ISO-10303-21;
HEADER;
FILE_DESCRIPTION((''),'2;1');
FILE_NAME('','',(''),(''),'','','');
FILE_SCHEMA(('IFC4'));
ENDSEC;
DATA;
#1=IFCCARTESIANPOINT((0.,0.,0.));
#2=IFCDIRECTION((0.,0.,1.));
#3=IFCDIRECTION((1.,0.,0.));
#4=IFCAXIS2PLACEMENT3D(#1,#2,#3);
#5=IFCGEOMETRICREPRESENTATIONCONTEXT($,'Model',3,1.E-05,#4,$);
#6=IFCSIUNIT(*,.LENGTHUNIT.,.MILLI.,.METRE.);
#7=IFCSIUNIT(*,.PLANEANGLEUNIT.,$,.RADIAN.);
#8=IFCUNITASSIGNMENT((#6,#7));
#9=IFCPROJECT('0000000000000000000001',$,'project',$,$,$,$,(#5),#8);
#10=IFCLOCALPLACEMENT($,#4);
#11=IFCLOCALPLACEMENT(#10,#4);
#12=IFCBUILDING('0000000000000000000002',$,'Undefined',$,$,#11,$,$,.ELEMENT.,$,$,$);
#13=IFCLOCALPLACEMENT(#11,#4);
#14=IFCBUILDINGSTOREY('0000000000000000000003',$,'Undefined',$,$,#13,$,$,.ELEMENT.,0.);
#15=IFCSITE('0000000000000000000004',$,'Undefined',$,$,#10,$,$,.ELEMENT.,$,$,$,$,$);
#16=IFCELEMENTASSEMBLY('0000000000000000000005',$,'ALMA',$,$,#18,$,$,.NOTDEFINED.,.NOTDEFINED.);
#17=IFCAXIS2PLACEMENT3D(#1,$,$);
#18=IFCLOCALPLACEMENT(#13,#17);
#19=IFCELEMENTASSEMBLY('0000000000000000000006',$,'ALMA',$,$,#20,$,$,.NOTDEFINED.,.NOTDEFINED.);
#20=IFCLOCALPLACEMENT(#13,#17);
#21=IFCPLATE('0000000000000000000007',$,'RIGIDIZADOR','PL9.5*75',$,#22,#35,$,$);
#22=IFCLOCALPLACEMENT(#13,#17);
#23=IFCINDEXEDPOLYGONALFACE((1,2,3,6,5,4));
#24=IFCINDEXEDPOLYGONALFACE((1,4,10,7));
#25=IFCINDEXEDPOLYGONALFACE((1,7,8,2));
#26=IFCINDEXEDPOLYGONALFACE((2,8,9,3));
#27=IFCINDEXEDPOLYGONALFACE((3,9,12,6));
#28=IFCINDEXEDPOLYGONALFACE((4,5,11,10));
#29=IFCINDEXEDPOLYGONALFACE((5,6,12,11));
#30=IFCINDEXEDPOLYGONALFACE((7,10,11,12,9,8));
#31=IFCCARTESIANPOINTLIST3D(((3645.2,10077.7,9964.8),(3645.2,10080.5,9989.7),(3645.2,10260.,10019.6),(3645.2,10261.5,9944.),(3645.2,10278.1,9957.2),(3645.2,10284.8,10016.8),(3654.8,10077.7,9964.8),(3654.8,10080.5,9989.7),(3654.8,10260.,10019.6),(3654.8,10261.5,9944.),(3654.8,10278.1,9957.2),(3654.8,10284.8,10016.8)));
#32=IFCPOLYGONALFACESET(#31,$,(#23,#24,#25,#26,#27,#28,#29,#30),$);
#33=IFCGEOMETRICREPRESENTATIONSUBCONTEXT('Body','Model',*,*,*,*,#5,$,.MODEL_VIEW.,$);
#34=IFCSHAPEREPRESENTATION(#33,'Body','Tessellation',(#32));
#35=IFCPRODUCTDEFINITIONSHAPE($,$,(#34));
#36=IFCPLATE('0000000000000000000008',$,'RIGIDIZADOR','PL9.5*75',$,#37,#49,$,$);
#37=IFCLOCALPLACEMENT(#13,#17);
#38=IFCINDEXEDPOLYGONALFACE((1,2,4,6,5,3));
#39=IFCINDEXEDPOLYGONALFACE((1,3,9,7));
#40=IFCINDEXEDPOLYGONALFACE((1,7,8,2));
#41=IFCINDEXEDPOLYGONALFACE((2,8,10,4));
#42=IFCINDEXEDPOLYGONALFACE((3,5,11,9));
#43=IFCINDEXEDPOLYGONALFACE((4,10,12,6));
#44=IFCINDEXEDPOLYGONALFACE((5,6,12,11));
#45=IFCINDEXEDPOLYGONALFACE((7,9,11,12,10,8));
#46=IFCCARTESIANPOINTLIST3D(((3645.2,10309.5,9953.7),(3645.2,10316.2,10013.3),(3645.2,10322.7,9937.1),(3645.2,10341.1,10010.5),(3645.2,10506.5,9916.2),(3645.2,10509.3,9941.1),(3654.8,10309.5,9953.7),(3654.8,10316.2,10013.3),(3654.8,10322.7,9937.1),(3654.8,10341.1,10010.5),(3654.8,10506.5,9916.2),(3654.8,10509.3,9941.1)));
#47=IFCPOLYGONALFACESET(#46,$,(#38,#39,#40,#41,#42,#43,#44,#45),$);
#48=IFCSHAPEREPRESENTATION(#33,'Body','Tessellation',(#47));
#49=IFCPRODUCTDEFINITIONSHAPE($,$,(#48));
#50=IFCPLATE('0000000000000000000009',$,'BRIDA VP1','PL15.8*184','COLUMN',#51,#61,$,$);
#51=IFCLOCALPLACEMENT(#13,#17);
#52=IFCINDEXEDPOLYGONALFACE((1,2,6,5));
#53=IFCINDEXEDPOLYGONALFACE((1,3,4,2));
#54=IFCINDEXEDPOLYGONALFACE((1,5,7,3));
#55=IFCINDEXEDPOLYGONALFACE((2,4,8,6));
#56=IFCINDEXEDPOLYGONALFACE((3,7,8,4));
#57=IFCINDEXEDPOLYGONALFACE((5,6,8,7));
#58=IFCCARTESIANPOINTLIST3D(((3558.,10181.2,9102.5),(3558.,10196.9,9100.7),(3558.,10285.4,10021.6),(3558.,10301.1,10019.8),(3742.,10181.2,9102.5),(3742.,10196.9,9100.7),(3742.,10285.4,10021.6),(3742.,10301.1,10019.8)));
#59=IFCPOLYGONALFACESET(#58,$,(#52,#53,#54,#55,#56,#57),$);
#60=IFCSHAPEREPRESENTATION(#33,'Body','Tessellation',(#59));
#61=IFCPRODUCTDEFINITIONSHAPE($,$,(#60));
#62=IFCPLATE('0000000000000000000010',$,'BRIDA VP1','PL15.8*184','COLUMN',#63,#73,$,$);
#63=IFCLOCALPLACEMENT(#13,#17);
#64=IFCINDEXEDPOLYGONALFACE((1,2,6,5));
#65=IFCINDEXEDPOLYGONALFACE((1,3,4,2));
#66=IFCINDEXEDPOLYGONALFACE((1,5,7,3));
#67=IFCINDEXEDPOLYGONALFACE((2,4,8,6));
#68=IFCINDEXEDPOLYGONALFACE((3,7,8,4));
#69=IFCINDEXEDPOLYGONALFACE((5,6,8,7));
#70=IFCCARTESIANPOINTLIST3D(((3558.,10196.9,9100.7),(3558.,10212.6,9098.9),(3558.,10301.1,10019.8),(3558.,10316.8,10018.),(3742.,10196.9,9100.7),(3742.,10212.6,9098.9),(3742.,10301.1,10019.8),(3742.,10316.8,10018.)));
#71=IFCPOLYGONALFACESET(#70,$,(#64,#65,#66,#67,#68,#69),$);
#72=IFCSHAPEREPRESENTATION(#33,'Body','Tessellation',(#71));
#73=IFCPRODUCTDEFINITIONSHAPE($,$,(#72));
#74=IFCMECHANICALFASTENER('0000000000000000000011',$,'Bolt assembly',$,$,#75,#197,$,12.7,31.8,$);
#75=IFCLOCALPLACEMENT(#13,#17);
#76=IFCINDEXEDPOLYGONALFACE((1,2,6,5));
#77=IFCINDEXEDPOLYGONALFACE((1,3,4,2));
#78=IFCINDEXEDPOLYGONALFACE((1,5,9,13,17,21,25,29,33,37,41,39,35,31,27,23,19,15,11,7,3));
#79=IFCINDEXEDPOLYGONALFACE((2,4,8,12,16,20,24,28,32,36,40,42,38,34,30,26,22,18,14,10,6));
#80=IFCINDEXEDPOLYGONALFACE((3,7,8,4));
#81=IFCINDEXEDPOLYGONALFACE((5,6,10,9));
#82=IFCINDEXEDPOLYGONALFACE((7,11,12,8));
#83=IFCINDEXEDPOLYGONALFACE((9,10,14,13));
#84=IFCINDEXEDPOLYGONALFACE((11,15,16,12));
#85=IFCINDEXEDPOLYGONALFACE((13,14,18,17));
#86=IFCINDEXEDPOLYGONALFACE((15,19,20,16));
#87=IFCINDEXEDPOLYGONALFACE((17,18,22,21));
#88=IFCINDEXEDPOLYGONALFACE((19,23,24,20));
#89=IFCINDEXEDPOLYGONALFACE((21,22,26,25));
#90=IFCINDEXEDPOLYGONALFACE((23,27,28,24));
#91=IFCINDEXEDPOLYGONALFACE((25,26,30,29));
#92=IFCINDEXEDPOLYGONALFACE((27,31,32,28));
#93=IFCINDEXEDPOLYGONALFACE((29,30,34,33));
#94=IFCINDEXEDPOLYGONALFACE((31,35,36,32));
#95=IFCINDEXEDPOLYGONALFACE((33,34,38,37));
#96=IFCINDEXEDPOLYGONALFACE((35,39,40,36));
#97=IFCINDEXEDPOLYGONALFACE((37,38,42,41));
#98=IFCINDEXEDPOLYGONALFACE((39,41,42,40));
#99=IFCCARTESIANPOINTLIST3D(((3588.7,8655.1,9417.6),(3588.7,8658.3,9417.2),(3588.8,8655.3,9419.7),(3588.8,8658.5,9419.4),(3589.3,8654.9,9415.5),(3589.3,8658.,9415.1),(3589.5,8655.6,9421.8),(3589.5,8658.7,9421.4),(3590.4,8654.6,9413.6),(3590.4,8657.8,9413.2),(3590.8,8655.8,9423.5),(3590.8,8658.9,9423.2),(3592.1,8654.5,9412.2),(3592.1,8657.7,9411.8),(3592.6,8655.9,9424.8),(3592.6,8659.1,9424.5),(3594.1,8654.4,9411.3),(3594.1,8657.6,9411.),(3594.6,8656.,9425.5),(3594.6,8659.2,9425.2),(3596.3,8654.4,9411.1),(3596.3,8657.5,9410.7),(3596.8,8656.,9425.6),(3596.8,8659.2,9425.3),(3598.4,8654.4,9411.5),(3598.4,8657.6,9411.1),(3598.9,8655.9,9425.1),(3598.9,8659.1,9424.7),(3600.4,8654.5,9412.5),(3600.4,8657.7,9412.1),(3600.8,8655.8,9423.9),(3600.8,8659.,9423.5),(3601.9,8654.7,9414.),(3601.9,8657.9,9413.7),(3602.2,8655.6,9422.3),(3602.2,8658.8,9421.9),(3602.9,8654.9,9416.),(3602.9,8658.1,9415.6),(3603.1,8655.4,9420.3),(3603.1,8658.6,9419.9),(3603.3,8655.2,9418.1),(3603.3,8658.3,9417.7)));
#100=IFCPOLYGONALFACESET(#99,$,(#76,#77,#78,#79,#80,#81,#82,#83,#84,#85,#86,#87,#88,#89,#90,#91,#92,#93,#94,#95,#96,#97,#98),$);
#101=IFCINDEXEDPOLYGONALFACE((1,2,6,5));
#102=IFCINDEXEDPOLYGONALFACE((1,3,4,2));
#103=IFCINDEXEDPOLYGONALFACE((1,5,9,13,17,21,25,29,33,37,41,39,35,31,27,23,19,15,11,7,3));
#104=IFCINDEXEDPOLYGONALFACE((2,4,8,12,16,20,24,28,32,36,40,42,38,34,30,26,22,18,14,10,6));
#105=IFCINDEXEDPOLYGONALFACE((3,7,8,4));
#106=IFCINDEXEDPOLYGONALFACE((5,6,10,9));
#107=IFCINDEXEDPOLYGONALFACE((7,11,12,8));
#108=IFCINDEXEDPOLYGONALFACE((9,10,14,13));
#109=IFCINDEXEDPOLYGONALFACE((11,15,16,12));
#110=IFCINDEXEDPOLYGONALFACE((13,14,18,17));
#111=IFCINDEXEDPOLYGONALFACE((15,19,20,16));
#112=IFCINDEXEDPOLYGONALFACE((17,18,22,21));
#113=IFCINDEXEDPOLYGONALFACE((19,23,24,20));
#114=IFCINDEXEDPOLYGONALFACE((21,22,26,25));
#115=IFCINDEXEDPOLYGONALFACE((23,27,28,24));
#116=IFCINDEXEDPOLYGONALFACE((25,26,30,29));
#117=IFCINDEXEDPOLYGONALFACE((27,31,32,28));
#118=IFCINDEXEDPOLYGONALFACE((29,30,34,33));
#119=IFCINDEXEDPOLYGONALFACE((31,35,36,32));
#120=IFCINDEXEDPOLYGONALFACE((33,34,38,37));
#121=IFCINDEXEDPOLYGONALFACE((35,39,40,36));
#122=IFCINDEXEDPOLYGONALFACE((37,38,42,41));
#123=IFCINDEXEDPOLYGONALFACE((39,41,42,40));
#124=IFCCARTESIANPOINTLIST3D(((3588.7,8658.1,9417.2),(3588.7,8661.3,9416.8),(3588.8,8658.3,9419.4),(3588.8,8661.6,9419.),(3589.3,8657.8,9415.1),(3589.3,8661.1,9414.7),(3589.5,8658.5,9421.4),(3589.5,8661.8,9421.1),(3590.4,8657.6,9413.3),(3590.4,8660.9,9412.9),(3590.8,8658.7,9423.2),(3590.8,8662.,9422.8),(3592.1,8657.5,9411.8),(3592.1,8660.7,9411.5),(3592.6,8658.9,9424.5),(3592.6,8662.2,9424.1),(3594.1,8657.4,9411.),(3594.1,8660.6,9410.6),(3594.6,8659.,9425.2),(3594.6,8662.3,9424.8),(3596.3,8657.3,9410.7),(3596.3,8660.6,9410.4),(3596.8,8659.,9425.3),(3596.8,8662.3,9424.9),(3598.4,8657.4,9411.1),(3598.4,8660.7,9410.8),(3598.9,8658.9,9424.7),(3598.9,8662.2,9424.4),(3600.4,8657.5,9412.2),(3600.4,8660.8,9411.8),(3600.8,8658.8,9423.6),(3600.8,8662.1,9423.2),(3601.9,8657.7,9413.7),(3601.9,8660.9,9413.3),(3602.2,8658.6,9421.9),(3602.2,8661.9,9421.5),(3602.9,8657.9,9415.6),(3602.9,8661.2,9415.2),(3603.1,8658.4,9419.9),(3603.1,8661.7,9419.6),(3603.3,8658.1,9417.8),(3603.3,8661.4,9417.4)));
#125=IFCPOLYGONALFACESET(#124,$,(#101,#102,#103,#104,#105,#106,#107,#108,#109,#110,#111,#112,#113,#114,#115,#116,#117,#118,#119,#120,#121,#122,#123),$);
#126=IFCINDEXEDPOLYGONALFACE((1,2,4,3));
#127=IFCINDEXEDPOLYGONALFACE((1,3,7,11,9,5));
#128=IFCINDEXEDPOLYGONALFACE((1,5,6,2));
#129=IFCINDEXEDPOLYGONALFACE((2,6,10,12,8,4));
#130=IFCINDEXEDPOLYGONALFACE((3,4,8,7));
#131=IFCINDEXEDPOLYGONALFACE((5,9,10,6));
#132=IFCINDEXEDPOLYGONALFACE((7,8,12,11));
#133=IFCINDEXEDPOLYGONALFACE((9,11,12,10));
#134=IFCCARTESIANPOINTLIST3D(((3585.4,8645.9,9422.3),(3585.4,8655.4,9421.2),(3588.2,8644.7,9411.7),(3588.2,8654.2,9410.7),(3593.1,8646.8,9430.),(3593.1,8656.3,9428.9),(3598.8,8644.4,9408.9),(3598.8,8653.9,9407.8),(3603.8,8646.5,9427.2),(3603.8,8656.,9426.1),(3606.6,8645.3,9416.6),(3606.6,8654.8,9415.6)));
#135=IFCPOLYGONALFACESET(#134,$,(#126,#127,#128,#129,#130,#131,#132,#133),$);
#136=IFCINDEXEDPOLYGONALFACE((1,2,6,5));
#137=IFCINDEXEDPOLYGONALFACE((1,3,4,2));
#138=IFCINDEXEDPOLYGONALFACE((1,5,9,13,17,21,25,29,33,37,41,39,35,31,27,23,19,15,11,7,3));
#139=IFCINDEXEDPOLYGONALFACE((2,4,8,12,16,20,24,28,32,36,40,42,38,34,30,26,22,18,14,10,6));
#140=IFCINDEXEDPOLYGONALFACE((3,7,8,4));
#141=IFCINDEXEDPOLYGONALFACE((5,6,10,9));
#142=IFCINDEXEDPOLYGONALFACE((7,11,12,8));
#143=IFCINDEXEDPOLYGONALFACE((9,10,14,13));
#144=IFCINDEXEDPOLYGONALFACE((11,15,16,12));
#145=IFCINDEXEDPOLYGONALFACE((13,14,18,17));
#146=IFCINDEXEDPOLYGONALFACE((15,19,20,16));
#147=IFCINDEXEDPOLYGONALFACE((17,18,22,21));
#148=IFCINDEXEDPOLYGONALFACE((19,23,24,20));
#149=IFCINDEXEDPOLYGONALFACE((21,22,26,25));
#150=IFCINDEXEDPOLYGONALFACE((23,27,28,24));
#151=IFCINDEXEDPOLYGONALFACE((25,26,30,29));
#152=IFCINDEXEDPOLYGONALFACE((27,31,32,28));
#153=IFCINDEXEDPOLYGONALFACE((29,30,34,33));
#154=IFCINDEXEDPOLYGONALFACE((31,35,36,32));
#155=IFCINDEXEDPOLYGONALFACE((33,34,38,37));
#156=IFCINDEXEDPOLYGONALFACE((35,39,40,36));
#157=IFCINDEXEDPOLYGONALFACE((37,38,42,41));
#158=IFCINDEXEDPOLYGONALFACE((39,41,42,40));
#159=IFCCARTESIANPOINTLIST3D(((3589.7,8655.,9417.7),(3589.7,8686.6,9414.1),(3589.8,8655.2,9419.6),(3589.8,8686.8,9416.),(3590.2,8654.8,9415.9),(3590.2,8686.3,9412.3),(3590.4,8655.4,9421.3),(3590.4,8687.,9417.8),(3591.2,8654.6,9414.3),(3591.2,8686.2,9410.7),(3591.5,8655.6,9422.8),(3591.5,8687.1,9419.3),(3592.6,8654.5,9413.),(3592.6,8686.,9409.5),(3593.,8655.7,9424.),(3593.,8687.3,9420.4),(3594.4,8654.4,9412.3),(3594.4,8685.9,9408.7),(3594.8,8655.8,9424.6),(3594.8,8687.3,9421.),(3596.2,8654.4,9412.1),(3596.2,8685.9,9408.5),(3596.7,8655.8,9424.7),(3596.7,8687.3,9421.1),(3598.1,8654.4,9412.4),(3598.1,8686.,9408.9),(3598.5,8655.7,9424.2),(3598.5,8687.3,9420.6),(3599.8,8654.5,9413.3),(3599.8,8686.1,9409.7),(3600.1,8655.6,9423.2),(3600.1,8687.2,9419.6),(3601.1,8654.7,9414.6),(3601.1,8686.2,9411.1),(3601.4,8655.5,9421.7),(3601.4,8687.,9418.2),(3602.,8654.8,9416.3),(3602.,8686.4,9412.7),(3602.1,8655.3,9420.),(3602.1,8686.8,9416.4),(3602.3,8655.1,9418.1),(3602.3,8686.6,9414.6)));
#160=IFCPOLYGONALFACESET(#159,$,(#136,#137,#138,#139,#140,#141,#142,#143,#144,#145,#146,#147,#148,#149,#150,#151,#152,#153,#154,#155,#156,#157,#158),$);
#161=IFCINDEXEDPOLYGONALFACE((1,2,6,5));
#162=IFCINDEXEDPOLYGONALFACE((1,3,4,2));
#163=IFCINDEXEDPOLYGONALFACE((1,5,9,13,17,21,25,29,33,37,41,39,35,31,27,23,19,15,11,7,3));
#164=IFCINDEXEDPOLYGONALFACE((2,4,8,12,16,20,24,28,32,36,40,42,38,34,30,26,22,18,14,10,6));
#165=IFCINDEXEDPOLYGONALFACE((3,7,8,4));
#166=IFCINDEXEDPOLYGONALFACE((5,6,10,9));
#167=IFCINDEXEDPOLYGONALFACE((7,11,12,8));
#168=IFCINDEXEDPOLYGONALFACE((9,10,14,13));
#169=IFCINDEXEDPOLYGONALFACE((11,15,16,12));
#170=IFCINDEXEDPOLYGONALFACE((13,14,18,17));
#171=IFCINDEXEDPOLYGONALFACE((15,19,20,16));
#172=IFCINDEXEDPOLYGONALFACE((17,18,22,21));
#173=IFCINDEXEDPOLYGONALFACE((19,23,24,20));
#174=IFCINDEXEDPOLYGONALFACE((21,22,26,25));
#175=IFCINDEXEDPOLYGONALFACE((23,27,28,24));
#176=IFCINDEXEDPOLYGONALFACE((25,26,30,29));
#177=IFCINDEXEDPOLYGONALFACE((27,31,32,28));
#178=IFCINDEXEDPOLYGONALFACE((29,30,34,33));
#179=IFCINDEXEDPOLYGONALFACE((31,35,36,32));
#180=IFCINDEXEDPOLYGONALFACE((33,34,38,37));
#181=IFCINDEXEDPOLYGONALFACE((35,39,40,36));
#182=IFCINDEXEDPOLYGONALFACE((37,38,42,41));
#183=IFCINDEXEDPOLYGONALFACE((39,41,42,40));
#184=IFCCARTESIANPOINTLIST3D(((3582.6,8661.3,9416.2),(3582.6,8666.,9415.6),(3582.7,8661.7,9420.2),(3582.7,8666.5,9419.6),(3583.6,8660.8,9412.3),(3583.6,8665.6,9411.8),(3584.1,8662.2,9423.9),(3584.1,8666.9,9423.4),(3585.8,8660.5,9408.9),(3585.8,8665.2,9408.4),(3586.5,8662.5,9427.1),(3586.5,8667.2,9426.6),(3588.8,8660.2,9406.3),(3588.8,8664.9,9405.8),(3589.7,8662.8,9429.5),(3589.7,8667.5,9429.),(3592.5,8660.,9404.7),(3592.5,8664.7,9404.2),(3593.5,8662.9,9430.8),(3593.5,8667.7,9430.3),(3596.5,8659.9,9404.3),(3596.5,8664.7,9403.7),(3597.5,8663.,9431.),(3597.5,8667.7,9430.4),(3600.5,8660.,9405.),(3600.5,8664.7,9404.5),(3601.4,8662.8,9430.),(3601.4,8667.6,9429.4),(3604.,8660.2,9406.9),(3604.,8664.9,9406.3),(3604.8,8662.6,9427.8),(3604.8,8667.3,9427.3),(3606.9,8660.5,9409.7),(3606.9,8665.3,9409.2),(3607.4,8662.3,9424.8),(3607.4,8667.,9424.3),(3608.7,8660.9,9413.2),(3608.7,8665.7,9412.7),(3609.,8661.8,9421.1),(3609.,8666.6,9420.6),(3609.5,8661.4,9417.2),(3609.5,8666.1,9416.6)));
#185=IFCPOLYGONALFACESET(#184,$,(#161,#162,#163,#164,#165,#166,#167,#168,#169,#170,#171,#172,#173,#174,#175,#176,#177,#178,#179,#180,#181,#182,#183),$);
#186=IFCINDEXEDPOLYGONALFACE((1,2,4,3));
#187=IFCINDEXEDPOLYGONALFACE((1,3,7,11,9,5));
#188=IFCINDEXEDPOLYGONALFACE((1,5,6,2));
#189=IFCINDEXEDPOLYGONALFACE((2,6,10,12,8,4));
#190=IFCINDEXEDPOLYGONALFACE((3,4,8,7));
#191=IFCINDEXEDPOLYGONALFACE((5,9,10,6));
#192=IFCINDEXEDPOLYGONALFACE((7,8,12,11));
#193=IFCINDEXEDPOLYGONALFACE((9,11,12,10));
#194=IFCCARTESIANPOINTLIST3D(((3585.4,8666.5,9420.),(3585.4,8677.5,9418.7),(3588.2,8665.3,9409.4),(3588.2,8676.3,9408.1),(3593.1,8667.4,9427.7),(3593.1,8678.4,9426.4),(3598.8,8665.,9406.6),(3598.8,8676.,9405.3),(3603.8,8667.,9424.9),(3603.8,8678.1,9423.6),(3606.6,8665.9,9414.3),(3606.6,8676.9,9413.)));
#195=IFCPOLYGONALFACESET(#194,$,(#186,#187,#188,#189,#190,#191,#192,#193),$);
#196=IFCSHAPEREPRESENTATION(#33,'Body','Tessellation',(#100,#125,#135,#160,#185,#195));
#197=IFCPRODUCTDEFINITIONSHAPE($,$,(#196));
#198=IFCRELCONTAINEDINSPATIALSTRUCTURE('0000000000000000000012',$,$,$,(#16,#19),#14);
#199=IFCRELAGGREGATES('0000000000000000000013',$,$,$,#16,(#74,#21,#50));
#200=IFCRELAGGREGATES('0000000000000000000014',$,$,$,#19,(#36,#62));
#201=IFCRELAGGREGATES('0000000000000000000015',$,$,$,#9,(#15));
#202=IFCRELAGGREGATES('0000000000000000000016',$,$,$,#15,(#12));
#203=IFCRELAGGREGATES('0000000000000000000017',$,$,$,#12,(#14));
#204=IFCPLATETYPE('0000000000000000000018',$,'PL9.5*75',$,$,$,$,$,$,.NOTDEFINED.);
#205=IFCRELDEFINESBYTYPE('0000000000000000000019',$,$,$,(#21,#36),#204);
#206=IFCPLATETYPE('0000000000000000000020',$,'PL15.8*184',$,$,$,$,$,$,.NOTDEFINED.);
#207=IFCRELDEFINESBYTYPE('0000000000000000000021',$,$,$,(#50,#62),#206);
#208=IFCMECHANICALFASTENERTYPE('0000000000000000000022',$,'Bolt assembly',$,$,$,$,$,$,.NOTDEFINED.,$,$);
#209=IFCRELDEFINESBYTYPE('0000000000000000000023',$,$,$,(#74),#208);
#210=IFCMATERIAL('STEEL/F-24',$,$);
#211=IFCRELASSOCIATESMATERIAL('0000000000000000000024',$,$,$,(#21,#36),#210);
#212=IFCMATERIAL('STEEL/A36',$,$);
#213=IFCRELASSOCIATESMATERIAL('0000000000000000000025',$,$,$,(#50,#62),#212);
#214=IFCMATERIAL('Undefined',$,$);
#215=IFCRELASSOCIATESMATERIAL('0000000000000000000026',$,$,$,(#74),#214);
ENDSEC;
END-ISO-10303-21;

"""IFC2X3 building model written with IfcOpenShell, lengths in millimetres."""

from ifc_helpers import new_model, si_unit, frame, origin_with_axes, origin_2d_with_axis, place, context, subcontext, project, spatial, polyline, circle, outline, extrude, source, transform, mapped, material, type_object, element, aggregate, save


model = new_model("IFC2X3")

# Units and contexts
model_context = context("Model", 3, precision=1e-05, world=origin_with_axes())
body_context = subcontext(model_context, "Body", "Model", "MODEL_VIEW")
ifc_project = project(units=[si_unit("LENGTHUNIT", "METRE", prefix="MILLI"), si_unit("PLANEANGLEUNIT", "RADIAN")], contexts=[model_context])

# Site, building, storey
site_placement = place(None, origin_with_axes())
site = spatial("IfcSite", under=ifc_project, at=site_placement, Name="Undefined", CompositionType="ELEMENT")
building_placement = place(site_placement, origin_with_axes())
building = spatial("IfcBuilding", under=site, at=building_placement, Name="Undefined", CompositionType="ELEMENT")
storey_placement = place(building_placement, origin_with_axes())
storey = spatial("IfcBuildingStorey", under=building, at=storey_placement, Name="Undefined", CompositionType="ELEMENT", Elevation=0.0)

# Shared definitions
ifc_material_1 = material(Name="STEEL/F-24")

# Element assemblies
assembly_1_placement = place(storey_placement, origin_with_axes())
assembly_1 = element("IfcElementAssembly", 1, at=assembly_1_placement, inside=storey, Name="ALMA", AssemblyPlace="NOTDEFINED", PredefinedType="NOTDEFINED")
assembly_2_placement = place(storey_placement, origin_with_axes())
assembly_2 = element("IfcElementAssembly", 2, at=assembly_2_placement, inside=storey, Name="ALMA", AssemblyPlace="NOTDEFINED", PredefinedType="NOTDEFINED")

# Plates
plate_type_1 = type_object("IfcPlateType", Name="PL9.5*75", PredefinedType="NOTDEFINED")
plate_1_placement = place(assembly_1_placement, frame((3650.0, 10276.4, 9942.3), z_axis=(-1.0, 0.0, 0.0), x_axis=(0.0, -0.993635, 0.112644)))
plate_1 = element("IfcPlate", 3, at=plate_1_placement, type_object=plate_type_1, material=ifc_material_1, Name="RIGIDIZADOR", Description="PL9.5*75", context=body_context, shape_type="SweptSolid", body=[
    extrude(outline(polyline([(0.0, 15.0), (15.0, 0.0), (200.0, 0.0), (200.0, 25.0), (25.0, 75.0), (0.0, 75.0), (0.0, 15.0)])), frame((0.0, 0.0, -4.8), z_axis=(0.0, 0.0, 1.0), x_axis=(1.0, 0.0, 0.0)), (0.0, 0.0, 1.0), 9.5),
])
plate_2_placement = place(assembly_2_placement, frame((3650.0, 10307.8, 9938.7), z_axis=(1.0, 0.0, 0.0), x_axis=(0.0, 0.993635, -0.112644)))
plate_2 = element("IfcPlate", 4, at=plate_2_placement, type_object=plate_type_1, material=ifc_material_1, Name="RIGIDIZADOR", Description="PL9.5*75", context=body_context, shape_type="SweptSolid", body=[
    extrude(outline(polyline([(0.0, 15.0), (15.0, 0.0), (200.0, 0.0), (200.0, 25.0), (25.0, 75.0), (0.0, 75.0), (0.0, 15.0)])), frame((0.0, 0.0, -4.8), z_axis=(0.0, 0.0, 1.0), x_axis=(1.0, 0.0, 0.0)), (0.0, 0.0, 1.0), 9.5),
])
ifc_material_2 = material(Name="STEEL/A36")
plate_type_2 = type_object("IfcPlateType", Name="PL15.8*184", PredefinedType="NOTDEFINED")
plate_3_placement = place(assembly_1_placement, frame((3650.0, 10293.2, 10020.7), z_axis=(0.0, 0.993635, -0.112644), x_axis=(0.0, -0.112644, -0.993635)))
plate_3 = element("IfcPlate", 5, at=plate_3_placement, type_object=plate_type_2, material=ifc_material_2, Name="BRIDA VP1", Description="PL15.8*184", ObjectType="COLUMN", context=body_context, shape_type="SweptSolid", body=[
    extrude(outline(polyline([(0.0, -92.0), (0.0, 92.0), (925.0, 92.0), (925.0, -92.0), (0.0, -92.0)])), frame((0.0, 0.0, -7.9), z_axis=(0.0, 0.0, 1.0), x_axis=(1.0, 0.0, 0.0)), (0.0, 0.0, 1.0), 15.8),
])
plate_4_placement = place(assembly_2_placement, frame((3650.0, 10308.9, 10018.9), z_axis=(0.0, 0.993635, -0.112644), x_axis=(0.0, -0.112644, -0.993635)))
plate_4 = element("IfcPlate", 6, at=plate_4_placement, type_object=plate_type_2, material=ifc_material_2, Name="BRIDA VP1", Description="PL15.8*184", ObjectType="COLUMN", context=body_context, shape_type="SweptSolid", body=[
    extrude(outline(polyline([(0.0, -92.0), (0.0, 92.0), (925.0, 92.0), (925.0, -92.0), (0.0, -92.0)])), frame((0.0, 0.0, -7.9), z_axis=(0.0, 0.0, 1.0), x_axis=(1.0, 0.0, 0.0)), (0.0, 0.0, 1.0), 15.8),
])

# Mechanical fastener
ifc_material_3 = material(Name="Undefined")
mechanical_fastener_type = type_object("IfcMechanicalFastenerType", Name="Bolt assembly")
shared_shape_1 = source(origin_with_axes(), body_context, "Body", "SweptSolid", [
    extrude(circle(Radius=7.3, at=origin_2d_with_axis()), frame((0.0, 0.1, 0.0), z_axis=(0.0, 1.0, 0.0), x_axis=(1.0, 0.0, 0.0)), (0.0, 0.0, 1.0), 3.2),
    extrude(circle(Radius=7.3, at=origin_2d_with_axis()), frame((0.0, 3.1, 0.0), z_axis=(0.0, 1.0, 0.0), x_axis=(1.0, 0.0, 0.0)), (0.0, 0.0, 1.0), 3.3),
    extrude(outline(polyline([(9.5, -5.5), (9.5, 5.5), (0.0, 11.0), (-9.5, 5.5), (-9.5, -5.5), (0.0, -11.0), (9.5, -5.5)])), frame((0.0, -9.5, 0.0), z_axis=(0.0, 1.0, 0.0), x_axis=(1.0, 0.0, 0.0)), (0.0, 0.0, 1.0), 9.5),
    extrude(circle(Radius=6.3, at=origin_2d_with_axis()), frame((0.0, 0.0, 0.0), z_axis=(0.0, 1.0, 0.0), x_axis=(1.0, 0.0, 0.0)), (0.0, 0.0, 1.0), 31.8),
    extrude(circle(Radius=13.5, at=origin_2d_with_axis()), frame((0.0, 6.4, 0.0), z_axis=(0.0, 1.0, 0.0), x_axis=(1.0, 0.0, 0.0)), (0.0, 0.0, 1.0), 4.8),
    extrude(outline(polyline([(9.5, -5.5), (9.5, 5.5), (0.0, 11.0), (-9.5, 5.5), (-9.5, -5.5), (0.0, -11.0), (9.5, -5.5)])), frame((0.0, 11.2, 0.0), z_axis=(0.0, 1.0, 0.0), x_axis=(1.0, 0.0, 0.0)), (0.0, 0.0, 1.0), 11.1),
])
mechanical_fastener_1_placement = place(assembly_1_placement, frame((3596.0, 8655.1, 9418.4), z_axis=(-0.707107, -0.079651, -0.702606), x_axis=(-0.707107, 0.079651, 0.702606)))
mechanical_fastener_1 = element("IfcMechanicalFastener", 7, at=mechanical_fastener_1_placement, type_object=mechanical_fastener_type, material=ifc_material_3, Name="Bolt assembly", NominalDiameter=12.7, NominalLength=31.8, context=body_context, shape_type="MappedRepresentation", body=[
    mapped(shared_shape_1, transform((0.0, 0.0, 0.0))),
])
aggregate(assembly_1, [mechanical_fastener_1, plate_1, plate_3])

aggregate(assembly_2, [plate_2, plate_4])

save(model, "model.ifc")
